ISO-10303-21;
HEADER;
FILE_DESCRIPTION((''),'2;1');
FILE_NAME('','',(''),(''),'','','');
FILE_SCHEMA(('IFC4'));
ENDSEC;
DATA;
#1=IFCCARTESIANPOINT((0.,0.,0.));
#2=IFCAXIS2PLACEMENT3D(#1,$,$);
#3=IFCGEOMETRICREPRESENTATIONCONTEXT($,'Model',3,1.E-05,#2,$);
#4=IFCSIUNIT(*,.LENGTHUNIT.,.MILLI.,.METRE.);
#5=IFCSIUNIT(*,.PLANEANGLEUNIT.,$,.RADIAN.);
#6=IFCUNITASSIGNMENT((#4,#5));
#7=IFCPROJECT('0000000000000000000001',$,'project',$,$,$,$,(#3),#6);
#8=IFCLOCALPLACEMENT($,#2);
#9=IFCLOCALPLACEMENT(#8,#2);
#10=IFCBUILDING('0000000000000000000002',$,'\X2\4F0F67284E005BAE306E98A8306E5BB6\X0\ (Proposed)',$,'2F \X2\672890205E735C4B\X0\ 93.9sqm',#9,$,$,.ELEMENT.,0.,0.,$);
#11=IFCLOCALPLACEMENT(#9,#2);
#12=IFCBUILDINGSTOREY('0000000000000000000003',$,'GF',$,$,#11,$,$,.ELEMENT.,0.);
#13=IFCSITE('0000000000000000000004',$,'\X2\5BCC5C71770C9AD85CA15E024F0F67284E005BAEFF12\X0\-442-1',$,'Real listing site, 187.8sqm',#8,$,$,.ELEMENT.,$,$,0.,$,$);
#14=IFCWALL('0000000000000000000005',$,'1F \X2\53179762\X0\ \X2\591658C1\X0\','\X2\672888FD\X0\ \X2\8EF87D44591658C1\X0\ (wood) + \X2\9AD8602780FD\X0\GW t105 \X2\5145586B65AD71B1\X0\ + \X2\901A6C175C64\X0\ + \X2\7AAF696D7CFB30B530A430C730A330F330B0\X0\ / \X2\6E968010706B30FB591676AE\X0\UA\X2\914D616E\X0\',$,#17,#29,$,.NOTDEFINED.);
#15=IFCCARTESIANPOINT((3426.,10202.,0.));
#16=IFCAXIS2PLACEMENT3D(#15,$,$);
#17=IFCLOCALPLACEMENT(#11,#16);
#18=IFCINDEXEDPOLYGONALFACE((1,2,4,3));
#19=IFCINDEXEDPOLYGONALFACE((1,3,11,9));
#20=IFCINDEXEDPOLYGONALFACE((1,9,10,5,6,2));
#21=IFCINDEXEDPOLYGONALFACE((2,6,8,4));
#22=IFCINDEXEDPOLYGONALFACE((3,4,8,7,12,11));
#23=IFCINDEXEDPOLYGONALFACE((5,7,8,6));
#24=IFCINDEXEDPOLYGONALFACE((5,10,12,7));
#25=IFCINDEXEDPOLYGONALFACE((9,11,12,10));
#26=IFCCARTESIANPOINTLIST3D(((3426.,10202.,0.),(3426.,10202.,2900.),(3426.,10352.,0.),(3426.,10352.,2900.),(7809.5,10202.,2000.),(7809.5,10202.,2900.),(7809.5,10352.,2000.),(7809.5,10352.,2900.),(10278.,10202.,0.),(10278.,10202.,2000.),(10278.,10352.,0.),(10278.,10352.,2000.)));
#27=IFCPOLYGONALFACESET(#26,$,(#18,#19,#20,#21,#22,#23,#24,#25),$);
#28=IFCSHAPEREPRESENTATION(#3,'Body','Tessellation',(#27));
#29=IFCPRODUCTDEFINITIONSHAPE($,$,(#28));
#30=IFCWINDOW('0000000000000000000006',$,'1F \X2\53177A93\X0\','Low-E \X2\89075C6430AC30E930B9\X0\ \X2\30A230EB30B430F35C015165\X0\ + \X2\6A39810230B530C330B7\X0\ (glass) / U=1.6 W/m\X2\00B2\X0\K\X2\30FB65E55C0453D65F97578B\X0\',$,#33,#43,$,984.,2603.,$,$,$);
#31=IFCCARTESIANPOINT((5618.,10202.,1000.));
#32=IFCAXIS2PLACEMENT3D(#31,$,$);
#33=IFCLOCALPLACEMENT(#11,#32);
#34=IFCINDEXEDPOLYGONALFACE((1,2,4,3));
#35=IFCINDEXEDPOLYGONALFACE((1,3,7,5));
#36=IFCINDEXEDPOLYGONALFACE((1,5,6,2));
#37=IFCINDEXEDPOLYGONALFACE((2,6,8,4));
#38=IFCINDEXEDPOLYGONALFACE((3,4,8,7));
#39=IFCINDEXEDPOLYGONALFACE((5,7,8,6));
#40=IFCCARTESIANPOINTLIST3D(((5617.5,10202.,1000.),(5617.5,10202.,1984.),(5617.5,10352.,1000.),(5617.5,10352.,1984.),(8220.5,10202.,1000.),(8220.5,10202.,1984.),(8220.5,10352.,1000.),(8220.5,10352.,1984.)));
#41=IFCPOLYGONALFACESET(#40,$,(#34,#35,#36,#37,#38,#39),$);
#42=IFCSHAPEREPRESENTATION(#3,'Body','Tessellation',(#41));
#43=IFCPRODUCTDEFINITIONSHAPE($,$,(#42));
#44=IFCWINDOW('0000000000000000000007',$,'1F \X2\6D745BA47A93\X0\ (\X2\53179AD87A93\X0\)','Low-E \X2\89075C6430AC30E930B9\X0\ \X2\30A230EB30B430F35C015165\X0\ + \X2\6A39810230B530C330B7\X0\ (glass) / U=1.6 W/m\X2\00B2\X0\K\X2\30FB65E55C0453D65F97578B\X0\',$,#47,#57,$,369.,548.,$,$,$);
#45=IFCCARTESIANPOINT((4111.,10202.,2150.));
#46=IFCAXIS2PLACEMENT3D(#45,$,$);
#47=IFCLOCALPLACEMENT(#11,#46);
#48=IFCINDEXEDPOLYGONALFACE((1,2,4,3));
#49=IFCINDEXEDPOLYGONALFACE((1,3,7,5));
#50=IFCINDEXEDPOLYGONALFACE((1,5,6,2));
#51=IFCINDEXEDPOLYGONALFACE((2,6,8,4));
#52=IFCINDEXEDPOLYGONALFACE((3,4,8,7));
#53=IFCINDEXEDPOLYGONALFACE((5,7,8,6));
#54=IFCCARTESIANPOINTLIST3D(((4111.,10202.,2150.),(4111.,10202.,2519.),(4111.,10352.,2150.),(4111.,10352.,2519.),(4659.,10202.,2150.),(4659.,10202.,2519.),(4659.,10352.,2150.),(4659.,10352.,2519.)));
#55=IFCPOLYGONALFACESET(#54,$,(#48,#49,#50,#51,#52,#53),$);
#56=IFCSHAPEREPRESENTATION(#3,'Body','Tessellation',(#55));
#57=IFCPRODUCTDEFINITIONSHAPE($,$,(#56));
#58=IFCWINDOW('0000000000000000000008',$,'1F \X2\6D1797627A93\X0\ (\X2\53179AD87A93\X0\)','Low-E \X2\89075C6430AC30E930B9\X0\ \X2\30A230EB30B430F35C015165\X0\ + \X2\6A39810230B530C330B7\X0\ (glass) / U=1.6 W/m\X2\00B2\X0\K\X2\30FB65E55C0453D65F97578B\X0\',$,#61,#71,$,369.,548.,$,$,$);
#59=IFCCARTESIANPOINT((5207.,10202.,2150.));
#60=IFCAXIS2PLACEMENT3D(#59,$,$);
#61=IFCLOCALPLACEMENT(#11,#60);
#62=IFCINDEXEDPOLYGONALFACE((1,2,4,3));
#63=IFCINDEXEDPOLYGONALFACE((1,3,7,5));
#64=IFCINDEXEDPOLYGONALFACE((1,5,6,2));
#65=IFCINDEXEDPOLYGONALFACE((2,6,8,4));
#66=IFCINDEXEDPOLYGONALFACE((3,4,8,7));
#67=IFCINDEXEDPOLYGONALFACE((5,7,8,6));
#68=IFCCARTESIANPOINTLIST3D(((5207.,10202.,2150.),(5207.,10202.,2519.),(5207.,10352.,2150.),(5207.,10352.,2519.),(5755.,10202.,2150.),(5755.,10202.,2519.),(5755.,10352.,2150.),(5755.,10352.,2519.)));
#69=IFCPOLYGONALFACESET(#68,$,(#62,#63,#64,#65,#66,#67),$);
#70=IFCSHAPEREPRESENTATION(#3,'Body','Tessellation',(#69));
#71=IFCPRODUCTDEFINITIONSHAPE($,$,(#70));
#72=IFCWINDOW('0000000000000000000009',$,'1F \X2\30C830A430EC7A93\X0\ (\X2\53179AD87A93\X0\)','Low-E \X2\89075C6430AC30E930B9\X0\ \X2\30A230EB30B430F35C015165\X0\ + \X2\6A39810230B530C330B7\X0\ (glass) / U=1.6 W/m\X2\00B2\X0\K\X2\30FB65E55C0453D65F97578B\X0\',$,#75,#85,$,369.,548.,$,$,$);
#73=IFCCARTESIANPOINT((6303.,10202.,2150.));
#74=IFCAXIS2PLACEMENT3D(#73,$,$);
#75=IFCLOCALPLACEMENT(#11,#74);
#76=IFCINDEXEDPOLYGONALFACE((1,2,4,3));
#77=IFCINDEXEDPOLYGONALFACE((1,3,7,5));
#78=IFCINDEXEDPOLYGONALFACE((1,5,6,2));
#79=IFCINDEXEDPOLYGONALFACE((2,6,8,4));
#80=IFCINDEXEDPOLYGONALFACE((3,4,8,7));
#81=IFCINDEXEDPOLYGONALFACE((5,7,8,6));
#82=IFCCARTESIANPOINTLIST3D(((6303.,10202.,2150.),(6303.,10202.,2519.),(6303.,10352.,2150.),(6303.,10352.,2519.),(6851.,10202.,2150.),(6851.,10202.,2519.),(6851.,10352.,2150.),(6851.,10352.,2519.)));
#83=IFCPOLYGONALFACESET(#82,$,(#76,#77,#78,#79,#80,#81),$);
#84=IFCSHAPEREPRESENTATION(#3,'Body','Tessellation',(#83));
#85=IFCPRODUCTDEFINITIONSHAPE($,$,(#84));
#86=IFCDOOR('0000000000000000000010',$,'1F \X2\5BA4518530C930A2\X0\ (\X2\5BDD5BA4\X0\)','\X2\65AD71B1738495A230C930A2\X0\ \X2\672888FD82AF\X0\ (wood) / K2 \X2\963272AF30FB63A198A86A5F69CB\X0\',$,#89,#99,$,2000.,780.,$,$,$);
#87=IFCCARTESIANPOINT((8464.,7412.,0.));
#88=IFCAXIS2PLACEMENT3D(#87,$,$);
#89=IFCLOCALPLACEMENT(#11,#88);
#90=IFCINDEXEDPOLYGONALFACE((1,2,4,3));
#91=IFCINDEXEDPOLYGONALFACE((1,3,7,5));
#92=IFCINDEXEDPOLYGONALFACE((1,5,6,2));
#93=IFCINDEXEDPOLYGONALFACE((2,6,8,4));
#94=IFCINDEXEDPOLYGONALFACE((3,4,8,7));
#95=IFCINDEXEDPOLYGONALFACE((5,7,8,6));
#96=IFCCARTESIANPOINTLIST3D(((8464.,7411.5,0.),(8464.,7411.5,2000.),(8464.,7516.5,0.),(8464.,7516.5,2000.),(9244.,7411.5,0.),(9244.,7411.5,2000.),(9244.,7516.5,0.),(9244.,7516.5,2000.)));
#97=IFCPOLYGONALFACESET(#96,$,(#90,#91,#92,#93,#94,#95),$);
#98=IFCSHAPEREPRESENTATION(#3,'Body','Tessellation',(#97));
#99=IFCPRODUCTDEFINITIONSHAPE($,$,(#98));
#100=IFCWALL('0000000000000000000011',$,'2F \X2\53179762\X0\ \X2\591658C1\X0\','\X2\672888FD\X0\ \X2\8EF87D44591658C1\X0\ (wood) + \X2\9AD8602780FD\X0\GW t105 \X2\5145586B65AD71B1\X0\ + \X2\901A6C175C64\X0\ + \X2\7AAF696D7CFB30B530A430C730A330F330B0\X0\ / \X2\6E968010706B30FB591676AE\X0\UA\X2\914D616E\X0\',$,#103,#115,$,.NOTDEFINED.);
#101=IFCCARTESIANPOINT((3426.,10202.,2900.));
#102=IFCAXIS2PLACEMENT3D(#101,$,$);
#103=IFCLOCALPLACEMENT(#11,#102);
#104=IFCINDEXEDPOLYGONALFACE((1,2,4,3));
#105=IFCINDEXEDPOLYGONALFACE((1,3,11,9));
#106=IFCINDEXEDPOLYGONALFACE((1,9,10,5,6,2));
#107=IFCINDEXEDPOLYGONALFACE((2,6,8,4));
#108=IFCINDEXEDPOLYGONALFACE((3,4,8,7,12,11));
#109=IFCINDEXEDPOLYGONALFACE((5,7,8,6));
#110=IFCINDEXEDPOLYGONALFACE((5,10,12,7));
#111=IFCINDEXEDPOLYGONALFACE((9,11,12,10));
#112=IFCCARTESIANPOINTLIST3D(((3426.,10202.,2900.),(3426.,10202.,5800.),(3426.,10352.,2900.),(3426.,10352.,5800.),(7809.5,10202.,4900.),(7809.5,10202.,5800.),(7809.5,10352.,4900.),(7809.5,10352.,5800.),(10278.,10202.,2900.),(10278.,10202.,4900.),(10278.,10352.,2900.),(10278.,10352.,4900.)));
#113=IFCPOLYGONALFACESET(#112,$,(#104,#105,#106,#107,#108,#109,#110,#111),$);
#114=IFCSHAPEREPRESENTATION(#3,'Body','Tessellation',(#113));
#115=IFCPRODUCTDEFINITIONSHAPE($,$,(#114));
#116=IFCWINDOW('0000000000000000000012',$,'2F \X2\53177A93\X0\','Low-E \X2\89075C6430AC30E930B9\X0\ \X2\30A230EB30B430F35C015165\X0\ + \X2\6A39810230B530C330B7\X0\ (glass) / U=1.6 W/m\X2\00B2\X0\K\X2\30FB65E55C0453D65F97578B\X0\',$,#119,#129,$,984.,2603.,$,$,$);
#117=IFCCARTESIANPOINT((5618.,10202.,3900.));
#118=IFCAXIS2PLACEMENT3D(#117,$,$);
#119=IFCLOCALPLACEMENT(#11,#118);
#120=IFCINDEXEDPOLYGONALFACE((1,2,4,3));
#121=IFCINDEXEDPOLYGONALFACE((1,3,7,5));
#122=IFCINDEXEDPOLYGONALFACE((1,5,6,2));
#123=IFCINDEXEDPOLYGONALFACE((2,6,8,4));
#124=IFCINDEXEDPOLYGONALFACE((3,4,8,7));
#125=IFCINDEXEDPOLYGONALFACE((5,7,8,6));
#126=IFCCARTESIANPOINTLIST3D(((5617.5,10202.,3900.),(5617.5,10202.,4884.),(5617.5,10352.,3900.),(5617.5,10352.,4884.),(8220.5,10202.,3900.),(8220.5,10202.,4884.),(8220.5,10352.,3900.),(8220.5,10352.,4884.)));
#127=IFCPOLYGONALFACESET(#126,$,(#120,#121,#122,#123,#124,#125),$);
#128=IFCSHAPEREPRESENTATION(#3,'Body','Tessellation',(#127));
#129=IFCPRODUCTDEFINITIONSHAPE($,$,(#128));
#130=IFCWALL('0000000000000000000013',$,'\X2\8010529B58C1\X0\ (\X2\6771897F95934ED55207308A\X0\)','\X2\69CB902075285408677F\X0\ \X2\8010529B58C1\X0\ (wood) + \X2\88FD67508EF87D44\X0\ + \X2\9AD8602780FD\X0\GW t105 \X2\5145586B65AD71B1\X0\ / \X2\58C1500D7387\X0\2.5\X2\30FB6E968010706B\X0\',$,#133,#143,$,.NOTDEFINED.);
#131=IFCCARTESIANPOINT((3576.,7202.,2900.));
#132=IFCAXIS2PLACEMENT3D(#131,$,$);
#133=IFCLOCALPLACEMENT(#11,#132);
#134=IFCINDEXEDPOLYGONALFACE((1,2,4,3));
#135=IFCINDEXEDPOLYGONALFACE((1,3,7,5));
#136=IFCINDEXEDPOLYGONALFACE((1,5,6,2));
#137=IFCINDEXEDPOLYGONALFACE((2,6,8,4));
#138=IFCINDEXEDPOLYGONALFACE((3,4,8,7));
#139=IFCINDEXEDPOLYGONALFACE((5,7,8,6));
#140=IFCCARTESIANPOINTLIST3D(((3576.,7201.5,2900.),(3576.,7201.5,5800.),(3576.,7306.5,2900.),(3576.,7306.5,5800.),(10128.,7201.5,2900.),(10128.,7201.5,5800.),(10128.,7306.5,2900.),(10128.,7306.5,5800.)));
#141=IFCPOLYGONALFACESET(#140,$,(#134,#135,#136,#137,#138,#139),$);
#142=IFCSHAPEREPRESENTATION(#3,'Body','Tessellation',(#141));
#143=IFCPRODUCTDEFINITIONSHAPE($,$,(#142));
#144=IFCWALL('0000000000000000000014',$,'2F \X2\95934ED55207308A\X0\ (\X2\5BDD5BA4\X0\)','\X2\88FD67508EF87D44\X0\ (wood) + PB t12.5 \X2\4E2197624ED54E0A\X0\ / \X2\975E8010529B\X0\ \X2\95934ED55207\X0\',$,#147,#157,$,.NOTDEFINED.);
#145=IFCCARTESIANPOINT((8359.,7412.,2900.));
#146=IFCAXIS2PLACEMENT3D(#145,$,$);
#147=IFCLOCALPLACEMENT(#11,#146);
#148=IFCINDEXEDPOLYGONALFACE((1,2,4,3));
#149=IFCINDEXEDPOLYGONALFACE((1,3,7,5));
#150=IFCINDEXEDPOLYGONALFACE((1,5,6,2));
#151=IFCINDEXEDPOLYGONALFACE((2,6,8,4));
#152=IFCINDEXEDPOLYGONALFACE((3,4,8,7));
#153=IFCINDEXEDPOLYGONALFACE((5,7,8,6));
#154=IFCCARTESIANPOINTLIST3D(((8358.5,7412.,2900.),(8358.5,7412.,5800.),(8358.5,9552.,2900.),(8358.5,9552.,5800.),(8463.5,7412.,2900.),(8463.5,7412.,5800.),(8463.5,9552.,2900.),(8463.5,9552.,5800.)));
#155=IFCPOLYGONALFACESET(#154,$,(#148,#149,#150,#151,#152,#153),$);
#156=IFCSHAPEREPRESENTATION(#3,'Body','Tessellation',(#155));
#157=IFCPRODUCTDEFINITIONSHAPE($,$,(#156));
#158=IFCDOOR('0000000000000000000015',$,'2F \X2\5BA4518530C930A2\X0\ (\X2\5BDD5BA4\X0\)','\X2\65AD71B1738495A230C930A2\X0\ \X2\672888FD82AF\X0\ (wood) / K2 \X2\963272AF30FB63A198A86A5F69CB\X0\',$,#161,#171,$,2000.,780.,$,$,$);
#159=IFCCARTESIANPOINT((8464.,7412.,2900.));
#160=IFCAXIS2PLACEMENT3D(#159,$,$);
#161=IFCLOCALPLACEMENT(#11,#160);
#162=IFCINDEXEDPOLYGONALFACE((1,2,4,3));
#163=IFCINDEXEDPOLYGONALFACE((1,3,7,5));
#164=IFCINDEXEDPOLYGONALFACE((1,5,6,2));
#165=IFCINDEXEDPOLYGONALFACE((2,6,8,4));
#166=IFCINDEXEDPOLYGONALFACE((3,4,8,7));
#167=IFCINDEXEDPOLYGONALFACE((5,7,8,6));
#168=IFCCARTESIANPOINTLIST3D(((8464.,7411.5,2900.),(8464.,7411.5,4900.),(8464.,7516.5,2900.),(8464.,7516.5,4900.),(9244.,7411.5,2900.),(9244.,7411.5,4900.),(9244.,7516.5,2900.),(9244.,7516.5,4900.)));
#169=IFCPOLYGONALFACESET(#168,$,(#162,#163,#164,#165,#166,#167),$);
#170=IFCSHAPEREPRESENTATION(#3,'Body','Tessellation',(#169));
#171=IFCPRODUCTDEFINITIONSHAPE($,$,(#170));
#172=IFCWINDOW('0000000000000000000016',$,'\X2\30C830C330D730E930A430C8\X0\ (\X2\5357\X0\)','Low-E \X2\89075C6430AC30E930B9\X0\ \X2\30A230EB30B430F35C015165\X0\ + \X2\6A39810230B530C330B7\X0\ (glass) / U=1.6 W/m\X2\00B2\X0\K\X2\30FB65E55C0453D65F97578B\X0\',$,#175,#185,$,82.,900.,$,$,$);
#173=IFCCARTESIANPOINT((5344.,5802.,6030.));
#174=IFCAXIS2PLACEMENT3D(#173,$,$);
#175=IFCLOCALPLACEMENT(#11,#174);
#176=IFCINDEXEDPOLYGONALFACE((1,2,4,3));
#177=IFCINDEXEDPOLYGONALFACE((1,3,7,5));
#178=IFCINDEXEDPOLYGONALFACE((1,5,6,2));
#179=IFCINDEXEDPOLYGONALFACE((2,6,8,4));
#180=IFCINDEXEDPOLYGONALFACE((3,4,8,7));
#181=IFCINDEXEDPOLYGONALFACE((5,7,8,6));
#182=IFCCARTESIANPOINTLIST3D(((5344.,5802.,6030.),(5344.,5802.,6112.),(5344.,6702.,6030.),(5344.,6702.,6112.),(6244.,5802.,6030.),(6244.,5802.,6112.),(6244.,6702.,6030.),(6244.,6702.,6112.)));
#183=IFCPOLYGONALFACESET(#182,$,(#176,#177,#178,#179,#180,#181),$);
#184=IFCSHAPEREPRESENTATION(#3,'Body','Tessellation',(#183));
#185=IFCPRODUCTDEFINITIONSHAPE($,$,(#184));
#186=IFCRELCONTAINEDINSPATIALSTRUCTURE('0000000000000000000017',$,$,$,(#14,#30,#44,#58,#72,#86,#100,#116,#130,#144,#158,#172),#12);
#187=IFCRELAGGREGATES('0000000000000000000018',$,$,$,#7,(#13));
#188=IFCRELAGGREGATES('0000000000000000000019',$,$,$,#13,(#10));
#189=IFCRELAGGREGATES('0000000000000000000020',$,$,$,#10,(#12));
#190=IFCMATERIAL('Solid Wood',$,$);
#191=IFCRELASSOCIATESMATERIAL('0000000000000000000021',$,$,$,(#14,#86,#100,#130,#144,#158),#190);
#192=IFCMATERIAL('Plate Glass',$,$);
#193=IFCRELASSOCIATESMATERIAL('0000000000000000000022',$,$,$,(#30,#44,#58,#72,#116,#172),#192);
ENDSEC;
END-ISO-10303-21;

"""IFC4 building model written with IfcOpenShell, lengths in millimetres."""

from ifc_helpers import new_model, si_unit, frame, frame_2d, origin, place, context, project, spatial, rectangle, extrude, material, element, fill, save


model = new_model("IFC4")

# Units and contexts
model_context = context("Model", 3, precision=1e-05, world=origin())
ifc_project = project(units=[si_unit("LENGTHUNIT", "METRE", prefix="MILLI"), si_unit("PLANEANGLEUNIT", "RADIAN")], contexts=[model_context])

# Site, building, storey
site_placement = place(None, origin())
site = spatial("IfcSite", under=ifc_project, at=site_placement, Name="富山県高岡市伏木一宮２-442-1", ObjectType="Real listing site, 187.8sqm", CompositionType="ELEMENT", RefElevation=0.0)
building_placement = place(site_placement, origin())
building = spatial("IfcBuilding", under=site, at=building_placement, Name="伏木一宮の風の家 (Proposed)", ObjectType="2F 木造平屋 93.9sqm", CompositionType="ELEMENT", ElevationOfRefHeight=0.0, ElevationOfTerrain=0.0)
storey_placement = place(building_placement, origin())
storey = spatial("IfcBuildingStorey", under=building, at=storey_placement, Name="GF", CompositionType="ELEMENT", Elevation=0.0)

# Wall, openings, windows
ifc_material_1 = material(Name="Solid Wood")
wall_1_placement = place(storey_placement, frame((3426.0, 10202.0, 0.0)))
wall_1 = element("IfcWall", 1, at=wall_1_placement, inside=storey, material=ifc_material_1, Name="1F 北面 外壁", Description="木製 軸組外壁 (wood) + 高性能GW t105 充填断熱 + 通気層 + 窯業系サイディング / 準耐火・外皮UA配慮", PredefinedType="NOTDEFINED", context=model_context, shape_type="SweptSolid", body=[
    extrude(rectangle(XDim=6852.0, YDim=150.0, at=frame_2d((3426.0, 75.0))), frame((3426.0, 10202.0, 0.0)), (0.0, 0.0, 1.0), 2900.0),
])
opening_1_placement = place(storey_placement, frame((5618.0, 10202.0, 1000.0)))
opening_1 = element("IfcOpeningElement", 2, at=opening_1_placement, cuts=wall_1, PredefinedType="NOTDEFINED", context=model_context, shape_type="SweptSolid", body=[
    extrude(rectangle(XDim=2603.0, YDim=150.0, at=frame_2d((1301.0, 75.0))), frame((5618.0, 10202.0, 1000.0)), (0.0, 0.0, 1.0), 984.0),
])
opening_2_placement = place(storey_placement, frame((4111.0, 10202.0, 2150.0)))
opening_2 = element("IfcOpeningElement", 3, at=opening_2_placement, cuts=wall_1, PredefinedType="NOTDEFINED", context=model_context, shape_type="SweptSolid", body=[
    extrude(rectangle(XDim=548.0, YDim=150.0, at=frame_2d((274.0, 75.0))), frame((4111.0, 10202.0, 2150.0)), (0.0, 0.0, 1.0), 369.0),
])
opening_3_placement = place(storey_placement, frame((5207.0, 10202.0, 2150.0)))
opening_3 = element("IfcOpeningElement", 4, at=opening_3_placement, cuts=wall_1, PredefinedType="NOTDEFINED", context=model_context, shape_type="SweptSolid", body=[
    extrude(rectangle(XDim=548.0, YDim=150.0, at=frame_2d((274.0, 75.0))), frame((5207.0, 10202.0, 2150.0)), (0.0, 0.0, 1.0), 369.0),
])
opening_4_placement = place(storey_placement, frame((6303.0, 10202.0, 2150.0)))
opening_4 = element("IfcOpeningElement", 5, at=opening_4_placement, cuts=wall_1, PredefinedType="NOTDEFINED", context=model_context, shape_type="SweptSolid", body=[
    extrude(rectangle(XDim=548.0, YDim=150.0, at=frame_2d((274.0, 75.0))), frame((6303.0, 10202.0, 2150.0)), (0.0, 0.0, 1.0), 369.0),
])
ifc_material_2 = material(Name="Plate Glass")
window_1_placement = place(storey_placement, frame((5618.0, 10202.0, 1000.0)))
window_1 = element("IfcWindow", 6, at=window_1_placement, inside=storey, material=ifc_material_2, Name="1F 北窓", Description="Low-E 複層ガラス アルゴン封入 + 樹脂サッシ (glass) / U=1.6 W/m²K・日射取得型", OverallHeight=984.0, OverallWidth=2603.0, context=model_context, shape_type="SweptSolid", body=[
    extrude(rectangle(XDim=2603.0, YDim=150.0, at=frame_2d((1301.0, 75.0))), frame((5618.0, 10202.0, 1000.0)), (0.0, 0.0, 1.0), 984.0),
])
fill(opening_1, window_1)
window_2_placement = place(storey_placement, frame((4111.0, 10202.0, 2150.0)))
window_2 = element("IfcWindow", 7, at=window_2_placement, inside=storey, material=ifc_material_2, Name="1F 浴室窓 (北高窓)", Description="Low-E 複層ガラス アルゴン封入 + 樹脂サッシ (glass) / U=1.6 W/m²K・日射取得型", OverallHeight=369.0, OverallWidth=548.0, context=model_context, shape_type="SweptSolid", body=[
    extrude(rectangle(XDim=548.0, YDim=150.0, at=frame_2d((274.0, 75.0))), frame((4111.0, 10202.0, 2150.0)), (0.0, 0.0, 1.0), 369.0),
])
fill(opening_2, window_2)
window_3_placement = place(storey_placement, frame((5207.0, 10202.0, 2150.0)))
window_3 = element("IfcWindow", 8, at=window_3_placement, inside=storey, material=ifc_material_2, Name="1F 洗面窓 (北高窓)", Description="Low-E 複層ガラス アルゴン封入 + 樹脂サッシ (glass) / U=1.6 W/m²K・日射取得型", OverallHeight=369.0, OverallWidth=548.0, context=model_context, shape_type="SweptSolid", body=[
    extrude(rectangle(XDim=548.0, YDim=150.0, at=frame_2d((274.0, 75.0))), frame((5207.0, 10202.0, 2150.0)), (0.0, 0.0, 1.0), 369.0),
])
fill(opening_3, window_3)
window_4_placement = place(storey_placement, frame((6303.0, 10202.0, 2150.0)))
window_4 = element("IfcWindow", 9, at=window_4_placement, inside=storey, material=ifc_material_2, Name="1F トイレ窓 (北高窓)", Description="Low-E 複層ガラス アルゴン封入 + 樹脂サッシ (glass) / U=1.6 W/m²K・日射取得型", OverallHeight=369.0, OverallWidth=548.0, context=model_context, shape_type="SweptSolid", body=[
    extrude(rectangle(XDim=548.0, YDim=150.0, at=frame_2d((274.0, 75.0))), frame((6303.0, 10202.0, 2150.0)), (0.0, 0.0, 1.0), 369.0),
])
fill(opening_4, window_4)

# Door
door_1_placement = place(storey_placement, frame((8464.0, 7412.0, 0.0)))
element("IfcDoor", 10, at=door_1_placement, inside=storey, material=ifc_material_1, Name="1F 室内ドア (寝室)", Description="断熱玄関ドア 木製芯 (wood) / K2 防犯・採風機構", OverallHeight=2000.0, OverallWidth=780.0, context=model_context, shape_type="SweptSolid", body=[
    extrude(rectangle(XDim=780.0, YDim=105.0, at=frame_2d((390.0, 52.0))), frame((8464.0, 7412.0, 0.0)), (0.0, 0.0, 1.0), 2000.0),
])

# Wall, opening, window
wall_2_placement = place(storey_placement, frame((3426.0, 10202.0, 2900.0)))
wall_2 = element("IfcWall", 11, at=wall_2_placement, inside=storey, material=ifc_material_1, Name="2F 北面 外壁", Description="木製 軸組外壁 (wood) + 高性能GW t105 充填断熱 + 通気層 + 窯業系サイディング / 準耐火・外皮UA配慮", PredefinedType="NOTDEFINED", context=model_context, shape_type="SweptSolid", body=[
    extrude(rectangle(XDim=6852.0, YDim=150.0, at=frame_2d((3426.0, 75.0))), frame((3426.0, 10202.0, 2900.0)), (0.0, 0.0, 1.0), 2900.0),
])
opening_5_placement = place(storey_placement, frame((5618.0, 10202.0, 3900.0)))
opening_5 = element("IfcOpeningElement", 12, at=opening_5_placement, cuts=wall_2, PredefinedType="NOTDEFINED", context=model_context, shape_type="SweptSolid", body=[
    extrude(rectangle(XDim=2603.0, YDim=150.0, at=frame_2d((1301.0, 75.0))), frame((5618.0, 10202.0, 3900.0)), (0.0, 0.0, 1.0), 984.0),
])
window_5_placement = place(storey_placement, frame((5618.0, 10202.0, 3900.0)))
window_5 = element("IfcWindow", 13, at=window_5_placement, inside=storey, material=ifc_material_2, Name="2F 北窓", Description="Low-E 複層ガラス アルゴン封入 + 樹脂サッシ (glass) / U=1.6 W/m²K・日射取得型", OverallHeight=984.0, OverallWidth=2603.0, context=model_context, shape_type="SweptSolid", body=[
    extrude(rectangle(XDim=2603.0, YDim=150.0, at=frame_2d((1301.0, 75.0))), frame((5618.0, 10202.0, 3900.0)), (0.0, 0.0, 1.0), 984.0),
])
fill(opening_5, window_5)

# Walls
wall_3_placement = place(storey_placement, frame((3576.0, 7202.0, 2900.0)))
element("IfcWall", 14, at=wall_3_placement, inside=storey, material=ifc_material_1, Name="耐力壁 (東西間仕切り)", Description="構造用合板 耐力壁 (wood) + 製材軸組 + 高性能GW t105 充填断熱 / 壁倍率2.5・準耐火", PredefinedType="NOTDEFINED", context=model_context, shape_type="SweptSolid", body=[
    extrude(rectangle(XDim=6552.0, YDim=105.0, at=frame_2d((3276.0, 52.0))), frame((3576.0, 7202.0, 2900.0)), (0.0, 0.0, 1.0), 2900.0),
])
wall_4_placement = place(storey_placement, frame((8359.0, 7412.0, 2900.0)))
element("IfcWall", 15, at=wall_4_placement, inside=storey, material=ifc_material_1, Name="2F 間仕切り (寝室)", Description="製材軸組 (wood) + PB t12.5 両面仕上 / 非耐力 間仕切", PredefinedType="NOTDEFINED", context=model_context, shape_type="SweptSolid", body=[
    extrude(rectangle(XDim=105.0, YDim=2140.0, at=frame_2d((52.0, 1070.0))), frame((8359.0, 7412.0, 2900.0)), (0.0, 0.0, 1.0), 2900.0),
])

# Door
door_2_placement = place(storey_placement, frame((8464.0, 7412.0, 2900.0)))
element("IfcDoor", 16, at=door_2_placement, inside=storey, material=ifc_material_1, Name="2F 室内ドア (寝室)", Description="断熱玄関ドア 木製芯 (wood) / K2 防犯・採風機構", OverallHeight=2000.0, OverallWidth=780.0, context=model_context, shape_type="SweptSolid", body=[
    extrude(rectangle(XDim=780.0, YDim=105.0, at=frame_2d((390.0, 52.0))), frame((8464.0, 7412.0, 2900.0)), (0.0, 0.0, 1.0), 2000.0),
])

# Window
window_6_placement = place(storey_placement, frame((5344.0, 5802.0, 6030.0)))
element("IfcWindow", 17, at=window_6_placement, inside=storey, material=ifc_material_2, Name="トップライト (南)", Description="Low-E 複層ガラス アルゴン封入 + 樹脂サッシ (glass) / U=1.6 W/m²K・日射取得型", OverallHeight=82.0, OverallWidth=900.0, context=model_context, shape_type="SweptSolid", body=[
    extrude(rectangle(XDim=900.0, YDim=900.0, at=frame_2d((450.0, 450.0))), frame((5344.0, 5802.0, 6030.0)), (0.0, 0.0, 1.0), 82.0),
])

save(model, "model.ifc")
